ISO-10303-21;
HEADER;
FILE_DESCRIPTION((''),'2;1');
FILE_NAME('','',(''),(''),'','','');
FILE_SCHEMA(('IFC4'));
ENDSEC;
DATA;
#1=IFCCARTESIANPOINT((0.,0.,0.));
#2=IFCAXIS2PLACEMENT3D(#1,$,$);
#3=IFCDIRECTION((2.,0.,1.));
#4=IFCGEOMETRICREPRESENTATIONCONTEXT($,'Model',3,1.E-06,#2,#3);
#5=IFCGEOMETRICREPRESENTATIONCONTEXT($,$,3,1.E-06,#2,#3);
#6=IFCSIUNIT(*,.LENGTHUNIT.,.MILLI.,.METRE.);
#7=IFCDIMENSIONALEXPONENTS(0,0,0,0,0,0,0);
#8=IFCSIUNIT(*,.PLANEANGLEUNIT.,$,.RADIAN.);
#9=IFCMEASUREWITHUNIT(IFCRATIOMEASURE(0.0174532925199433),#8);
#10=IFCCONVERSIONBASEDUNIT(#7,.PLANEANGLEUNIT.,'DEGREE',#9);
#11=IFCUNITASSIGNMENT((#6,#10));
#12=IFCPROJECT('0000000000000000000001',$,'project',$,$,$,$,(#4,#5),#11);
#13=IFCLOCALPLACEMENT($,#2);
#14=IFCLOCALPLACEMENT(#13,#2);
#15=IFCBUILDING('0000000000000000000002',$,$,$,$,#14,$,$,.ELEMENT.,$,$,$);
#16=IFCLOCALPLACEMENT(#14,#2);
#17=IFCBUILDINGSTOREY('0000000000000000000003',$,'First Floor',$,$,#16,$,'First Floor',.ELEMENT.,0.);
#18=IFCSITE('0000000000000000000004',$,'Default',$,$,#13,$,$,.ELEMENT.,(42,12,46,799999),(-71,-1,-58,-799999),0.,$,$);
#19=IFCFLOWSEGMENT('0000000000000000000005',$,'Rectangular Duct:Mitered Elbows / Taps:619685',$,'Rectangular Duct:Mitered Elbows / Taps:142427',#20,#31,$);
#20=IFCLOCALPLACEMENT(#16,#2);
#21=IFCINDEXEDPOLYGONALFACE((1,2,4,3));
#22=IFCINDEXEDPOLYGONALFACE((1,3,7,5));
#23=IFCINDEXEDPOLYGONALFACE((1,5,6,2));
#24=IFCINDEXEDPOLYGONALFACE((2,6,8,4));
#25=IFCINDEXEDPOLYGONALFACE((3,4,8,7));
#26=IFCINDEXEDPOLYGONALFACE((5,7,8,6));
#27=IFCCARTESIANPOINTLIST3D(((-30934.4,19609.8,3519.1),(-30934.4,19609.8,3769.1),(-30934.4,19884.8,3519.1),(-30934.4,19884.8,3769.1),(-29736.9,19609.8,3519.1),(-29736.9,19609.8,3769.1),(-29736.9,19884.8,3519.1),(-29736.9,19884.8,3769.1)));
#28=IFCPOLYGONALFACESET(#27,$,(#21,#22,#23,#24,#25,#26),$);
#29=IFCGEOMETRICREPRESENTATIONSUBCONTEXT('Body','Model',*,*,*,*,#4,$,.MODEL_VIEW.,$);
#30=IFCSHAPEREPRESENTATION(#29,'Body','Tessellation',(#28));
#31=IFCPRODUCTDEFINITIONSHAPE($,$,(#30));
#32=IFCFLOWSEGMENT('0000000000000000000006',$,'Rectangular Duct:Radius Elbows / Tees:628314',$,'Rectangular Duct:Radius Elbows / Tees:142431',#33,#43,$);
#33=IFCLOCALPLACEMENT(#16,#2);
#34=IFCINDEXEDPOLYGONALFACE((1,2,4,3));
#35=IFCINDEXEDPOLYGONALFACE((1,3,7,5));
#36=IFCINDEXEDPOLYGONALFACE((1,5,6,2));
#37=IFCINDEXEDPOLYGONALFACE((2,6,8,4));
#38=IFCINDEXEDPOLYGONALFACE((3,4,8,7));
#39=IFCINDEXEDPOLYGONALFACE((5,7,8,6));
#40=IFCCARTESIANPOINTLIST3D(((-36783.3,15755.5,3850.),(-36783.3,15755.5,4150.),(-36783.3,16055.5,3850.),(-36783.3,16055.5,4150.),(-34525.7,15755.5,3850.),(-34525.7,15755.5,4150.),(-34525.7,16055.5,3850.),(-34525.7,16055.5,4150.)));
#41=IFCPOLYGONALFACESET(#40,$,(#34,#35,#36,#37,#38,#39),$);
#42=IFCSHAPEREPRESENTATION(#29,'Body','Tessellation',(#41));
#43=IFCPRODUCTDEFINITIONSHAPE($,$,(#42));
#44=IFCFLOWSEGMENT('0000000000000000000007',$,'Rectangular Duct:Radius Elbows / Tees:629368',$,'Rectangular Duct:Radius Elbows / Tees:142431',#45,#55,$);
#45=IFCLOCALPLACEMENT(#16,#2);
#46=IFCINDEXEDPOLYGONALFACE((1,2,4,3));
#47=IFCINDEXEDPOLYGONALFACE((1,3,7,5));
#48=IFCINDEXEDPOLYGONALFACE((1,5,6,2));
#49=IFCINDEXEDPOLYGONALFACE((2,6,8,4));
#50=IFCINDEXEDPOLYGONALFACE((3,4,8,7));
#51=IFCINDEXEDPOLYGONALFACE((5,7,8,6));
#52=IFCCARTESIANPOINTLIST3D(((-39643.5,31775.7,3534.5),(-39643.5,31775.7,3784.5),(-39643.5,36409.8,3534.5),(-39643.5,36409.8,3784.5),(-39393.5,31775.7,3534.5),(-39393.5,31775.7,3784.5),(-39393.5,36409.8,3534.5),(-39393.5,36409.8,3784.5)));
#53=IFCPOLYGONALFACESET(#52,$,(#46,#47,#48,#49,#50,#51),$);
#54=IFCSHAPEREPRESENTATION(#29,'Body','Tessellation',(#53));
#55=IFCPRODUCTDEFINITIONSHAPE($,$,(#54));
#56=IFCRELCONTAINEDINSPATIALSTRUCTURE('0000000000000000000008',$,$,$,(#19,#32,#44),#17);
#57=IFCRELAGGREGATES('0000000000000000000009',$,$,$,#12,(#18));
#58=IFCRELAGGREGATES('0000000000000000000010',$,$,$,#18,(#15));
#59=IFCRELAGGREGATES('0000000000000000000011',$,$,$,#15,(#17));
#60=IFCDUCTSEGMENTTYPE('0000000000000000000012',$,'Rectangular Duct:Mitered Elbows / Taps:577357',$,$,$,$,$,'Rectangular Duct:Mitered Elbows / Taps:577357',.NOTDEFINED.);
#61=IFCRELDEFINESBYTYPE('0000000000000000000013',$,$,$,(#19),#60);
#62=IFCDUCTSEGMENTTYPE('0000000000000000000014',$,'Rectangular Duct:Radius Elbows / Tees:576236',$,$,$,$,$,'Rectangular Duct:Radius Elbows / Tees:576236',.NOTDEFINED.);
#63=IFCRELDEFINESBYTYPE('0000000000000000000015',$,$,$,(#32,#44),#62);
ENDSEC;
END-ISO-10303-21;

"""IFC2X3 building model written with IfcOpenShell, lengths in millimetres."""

from ifc_helpers import new_model, entity, si_unit, converted_unit, direction, frame, frame_2d, origin, place, context, subcontext, project, spatial, rectangle, extrude, type_object, element, save


model = new_model("IFC2X3")

# Units and contexts
model_context = context("Model", 3, precision=1e-06, world=origin(), true_north=direction((2.0, 0.0, 1.0)))
context_of_model = context(None, 3, precision=1e-06, world=origin(), true_north=direction((2.0, 0.0, 1.0)))
body_context = subcontext(model_context, "Body", "Model", "MODEL_VIEW")
ifc_project = project(units=[si_unit("LENGTHUNIT", "METRE", prefix="MILLI"), converted_unit("PLANEANGLEUNIT", "DEGREE", entity("IfcRatioMeasure", 0.0174532925199433), si_unit("PLANEANGLEUNIT", "RADIAN"), dimensions=[0, 0, 0, 0, 0, 0, 0])], contexts=[model_context, context_of_model])

# Site, building, storey
site_placement = place(None, origin())
site = spatial("IfcSite", under=ifc_project, at=site_placement, Name="Default", CompositionType="ELEMENT", RefLatitude=(42, 12, 46, 799999), RefLongitude=(-71, -1, -58, -799999), RefElevation=0.0)
building_placement = place(site_placement, origin())
building = spatial("IfcBuilding", under=site, at=building_placement, CompositionType="ELEMENT")
storey_placement = place(building_placement, origin())
storey = spatial("IfcBuildingStorey", under=building, at=storey_placement, Name="First Floor", LongName="First Floor", CompositionType="ELEMENT", Elevation=0.0)

# Flow segments
duct_segment_type_1 = type_object("IfcDuctSegmentType", Name="Rectangular Duct:Mitered Elbows / Taps:577357", ElementType="Rectangular Duct:Mitered Elbows / Taps:577357", PredefinedType="NOTDEFINED")
flow_segment_1_placement = place(storey_placement, origin())
element("IfcFlowSegment", 1, at=flow_segment_1_placement, inside=storey, type_object=duct_segment_type_1, Name="Rectangular Duct:Mitered Elbows / Taps:619685", ObjectType="Rectangular Duct:Mitered Elbows / Taps:142427", context=body_context, shape_type="SweptSolid", body=[
    extrude(rectangle(XDim=1197.5, YDim=275.0, at=frame_2d((0.0, 0.0), x_axis=(1.0, 0.0))), frame((-30335.7, 19747.3, 3519.1), z_axis=(0.0, 0.0, 1.0), x_axis=(-1.0, 0.0, 0.0)), (0.0, 0.0, 1.0), 250.0),
])
duct_segment_type_2 = type_object("IfcDuctSegmentType", Name="Rectangular Duct:Radius Elbows / Tees:576236", ElementType="Rectangular Duct:Radius Elbows / Tees:576236", PredefinedType="NOTDEFINED")
flow_segment_2_placement = place(storey_placement, origin())
element("IfcFlowSegment", 2, at=flow_segment_2_placement, inside=storey, type_object=duct_segment_type_2, Name="Rectangular Duct:Radius Elbows / Tees:628314", ObjectType="Rectangular Duct:Radius Elbows / Tees:142431", context=body_context, shape_type="SweptSolid", body=[
    extrude(rectangle(XDim=2257.5, YDim=300.0, at=frame_2d((0.0, 0.0), x_axis=(1.0, 0.0))), frame((-35654.5, 15905.5, 3850.0)), (0.0, 0.0, 1.0), 300.0),
])
flow_segment_3_placement = place(storey_placement, origin())
element("IfcFlowSegment", 3, at=flow_segment_3_placement, inside=storey, type_object=duct_segment_type_2, Name="Rectangular Duct:Radius Elbows / Tees:629368", ObjectType="Rectangular Duct:Radius Elbows / Tees:142431", context=body_context, shape_type="SweptSolid", body=[
    extrude(rectangle(XDim=4634.1, YDim=250.0, at=frame_2d((0.0, 0.0), x_axis=(1.0, 0.0))), frame((-39518.5, 34092.7, 3534.5), z_axis=(0.0, 0.0, 1.0), x_axis=(0.0, -1.0, 0.0)), (0.0, 0.0, 1.0), 250.0),
])

save(model, "model.ifc")
